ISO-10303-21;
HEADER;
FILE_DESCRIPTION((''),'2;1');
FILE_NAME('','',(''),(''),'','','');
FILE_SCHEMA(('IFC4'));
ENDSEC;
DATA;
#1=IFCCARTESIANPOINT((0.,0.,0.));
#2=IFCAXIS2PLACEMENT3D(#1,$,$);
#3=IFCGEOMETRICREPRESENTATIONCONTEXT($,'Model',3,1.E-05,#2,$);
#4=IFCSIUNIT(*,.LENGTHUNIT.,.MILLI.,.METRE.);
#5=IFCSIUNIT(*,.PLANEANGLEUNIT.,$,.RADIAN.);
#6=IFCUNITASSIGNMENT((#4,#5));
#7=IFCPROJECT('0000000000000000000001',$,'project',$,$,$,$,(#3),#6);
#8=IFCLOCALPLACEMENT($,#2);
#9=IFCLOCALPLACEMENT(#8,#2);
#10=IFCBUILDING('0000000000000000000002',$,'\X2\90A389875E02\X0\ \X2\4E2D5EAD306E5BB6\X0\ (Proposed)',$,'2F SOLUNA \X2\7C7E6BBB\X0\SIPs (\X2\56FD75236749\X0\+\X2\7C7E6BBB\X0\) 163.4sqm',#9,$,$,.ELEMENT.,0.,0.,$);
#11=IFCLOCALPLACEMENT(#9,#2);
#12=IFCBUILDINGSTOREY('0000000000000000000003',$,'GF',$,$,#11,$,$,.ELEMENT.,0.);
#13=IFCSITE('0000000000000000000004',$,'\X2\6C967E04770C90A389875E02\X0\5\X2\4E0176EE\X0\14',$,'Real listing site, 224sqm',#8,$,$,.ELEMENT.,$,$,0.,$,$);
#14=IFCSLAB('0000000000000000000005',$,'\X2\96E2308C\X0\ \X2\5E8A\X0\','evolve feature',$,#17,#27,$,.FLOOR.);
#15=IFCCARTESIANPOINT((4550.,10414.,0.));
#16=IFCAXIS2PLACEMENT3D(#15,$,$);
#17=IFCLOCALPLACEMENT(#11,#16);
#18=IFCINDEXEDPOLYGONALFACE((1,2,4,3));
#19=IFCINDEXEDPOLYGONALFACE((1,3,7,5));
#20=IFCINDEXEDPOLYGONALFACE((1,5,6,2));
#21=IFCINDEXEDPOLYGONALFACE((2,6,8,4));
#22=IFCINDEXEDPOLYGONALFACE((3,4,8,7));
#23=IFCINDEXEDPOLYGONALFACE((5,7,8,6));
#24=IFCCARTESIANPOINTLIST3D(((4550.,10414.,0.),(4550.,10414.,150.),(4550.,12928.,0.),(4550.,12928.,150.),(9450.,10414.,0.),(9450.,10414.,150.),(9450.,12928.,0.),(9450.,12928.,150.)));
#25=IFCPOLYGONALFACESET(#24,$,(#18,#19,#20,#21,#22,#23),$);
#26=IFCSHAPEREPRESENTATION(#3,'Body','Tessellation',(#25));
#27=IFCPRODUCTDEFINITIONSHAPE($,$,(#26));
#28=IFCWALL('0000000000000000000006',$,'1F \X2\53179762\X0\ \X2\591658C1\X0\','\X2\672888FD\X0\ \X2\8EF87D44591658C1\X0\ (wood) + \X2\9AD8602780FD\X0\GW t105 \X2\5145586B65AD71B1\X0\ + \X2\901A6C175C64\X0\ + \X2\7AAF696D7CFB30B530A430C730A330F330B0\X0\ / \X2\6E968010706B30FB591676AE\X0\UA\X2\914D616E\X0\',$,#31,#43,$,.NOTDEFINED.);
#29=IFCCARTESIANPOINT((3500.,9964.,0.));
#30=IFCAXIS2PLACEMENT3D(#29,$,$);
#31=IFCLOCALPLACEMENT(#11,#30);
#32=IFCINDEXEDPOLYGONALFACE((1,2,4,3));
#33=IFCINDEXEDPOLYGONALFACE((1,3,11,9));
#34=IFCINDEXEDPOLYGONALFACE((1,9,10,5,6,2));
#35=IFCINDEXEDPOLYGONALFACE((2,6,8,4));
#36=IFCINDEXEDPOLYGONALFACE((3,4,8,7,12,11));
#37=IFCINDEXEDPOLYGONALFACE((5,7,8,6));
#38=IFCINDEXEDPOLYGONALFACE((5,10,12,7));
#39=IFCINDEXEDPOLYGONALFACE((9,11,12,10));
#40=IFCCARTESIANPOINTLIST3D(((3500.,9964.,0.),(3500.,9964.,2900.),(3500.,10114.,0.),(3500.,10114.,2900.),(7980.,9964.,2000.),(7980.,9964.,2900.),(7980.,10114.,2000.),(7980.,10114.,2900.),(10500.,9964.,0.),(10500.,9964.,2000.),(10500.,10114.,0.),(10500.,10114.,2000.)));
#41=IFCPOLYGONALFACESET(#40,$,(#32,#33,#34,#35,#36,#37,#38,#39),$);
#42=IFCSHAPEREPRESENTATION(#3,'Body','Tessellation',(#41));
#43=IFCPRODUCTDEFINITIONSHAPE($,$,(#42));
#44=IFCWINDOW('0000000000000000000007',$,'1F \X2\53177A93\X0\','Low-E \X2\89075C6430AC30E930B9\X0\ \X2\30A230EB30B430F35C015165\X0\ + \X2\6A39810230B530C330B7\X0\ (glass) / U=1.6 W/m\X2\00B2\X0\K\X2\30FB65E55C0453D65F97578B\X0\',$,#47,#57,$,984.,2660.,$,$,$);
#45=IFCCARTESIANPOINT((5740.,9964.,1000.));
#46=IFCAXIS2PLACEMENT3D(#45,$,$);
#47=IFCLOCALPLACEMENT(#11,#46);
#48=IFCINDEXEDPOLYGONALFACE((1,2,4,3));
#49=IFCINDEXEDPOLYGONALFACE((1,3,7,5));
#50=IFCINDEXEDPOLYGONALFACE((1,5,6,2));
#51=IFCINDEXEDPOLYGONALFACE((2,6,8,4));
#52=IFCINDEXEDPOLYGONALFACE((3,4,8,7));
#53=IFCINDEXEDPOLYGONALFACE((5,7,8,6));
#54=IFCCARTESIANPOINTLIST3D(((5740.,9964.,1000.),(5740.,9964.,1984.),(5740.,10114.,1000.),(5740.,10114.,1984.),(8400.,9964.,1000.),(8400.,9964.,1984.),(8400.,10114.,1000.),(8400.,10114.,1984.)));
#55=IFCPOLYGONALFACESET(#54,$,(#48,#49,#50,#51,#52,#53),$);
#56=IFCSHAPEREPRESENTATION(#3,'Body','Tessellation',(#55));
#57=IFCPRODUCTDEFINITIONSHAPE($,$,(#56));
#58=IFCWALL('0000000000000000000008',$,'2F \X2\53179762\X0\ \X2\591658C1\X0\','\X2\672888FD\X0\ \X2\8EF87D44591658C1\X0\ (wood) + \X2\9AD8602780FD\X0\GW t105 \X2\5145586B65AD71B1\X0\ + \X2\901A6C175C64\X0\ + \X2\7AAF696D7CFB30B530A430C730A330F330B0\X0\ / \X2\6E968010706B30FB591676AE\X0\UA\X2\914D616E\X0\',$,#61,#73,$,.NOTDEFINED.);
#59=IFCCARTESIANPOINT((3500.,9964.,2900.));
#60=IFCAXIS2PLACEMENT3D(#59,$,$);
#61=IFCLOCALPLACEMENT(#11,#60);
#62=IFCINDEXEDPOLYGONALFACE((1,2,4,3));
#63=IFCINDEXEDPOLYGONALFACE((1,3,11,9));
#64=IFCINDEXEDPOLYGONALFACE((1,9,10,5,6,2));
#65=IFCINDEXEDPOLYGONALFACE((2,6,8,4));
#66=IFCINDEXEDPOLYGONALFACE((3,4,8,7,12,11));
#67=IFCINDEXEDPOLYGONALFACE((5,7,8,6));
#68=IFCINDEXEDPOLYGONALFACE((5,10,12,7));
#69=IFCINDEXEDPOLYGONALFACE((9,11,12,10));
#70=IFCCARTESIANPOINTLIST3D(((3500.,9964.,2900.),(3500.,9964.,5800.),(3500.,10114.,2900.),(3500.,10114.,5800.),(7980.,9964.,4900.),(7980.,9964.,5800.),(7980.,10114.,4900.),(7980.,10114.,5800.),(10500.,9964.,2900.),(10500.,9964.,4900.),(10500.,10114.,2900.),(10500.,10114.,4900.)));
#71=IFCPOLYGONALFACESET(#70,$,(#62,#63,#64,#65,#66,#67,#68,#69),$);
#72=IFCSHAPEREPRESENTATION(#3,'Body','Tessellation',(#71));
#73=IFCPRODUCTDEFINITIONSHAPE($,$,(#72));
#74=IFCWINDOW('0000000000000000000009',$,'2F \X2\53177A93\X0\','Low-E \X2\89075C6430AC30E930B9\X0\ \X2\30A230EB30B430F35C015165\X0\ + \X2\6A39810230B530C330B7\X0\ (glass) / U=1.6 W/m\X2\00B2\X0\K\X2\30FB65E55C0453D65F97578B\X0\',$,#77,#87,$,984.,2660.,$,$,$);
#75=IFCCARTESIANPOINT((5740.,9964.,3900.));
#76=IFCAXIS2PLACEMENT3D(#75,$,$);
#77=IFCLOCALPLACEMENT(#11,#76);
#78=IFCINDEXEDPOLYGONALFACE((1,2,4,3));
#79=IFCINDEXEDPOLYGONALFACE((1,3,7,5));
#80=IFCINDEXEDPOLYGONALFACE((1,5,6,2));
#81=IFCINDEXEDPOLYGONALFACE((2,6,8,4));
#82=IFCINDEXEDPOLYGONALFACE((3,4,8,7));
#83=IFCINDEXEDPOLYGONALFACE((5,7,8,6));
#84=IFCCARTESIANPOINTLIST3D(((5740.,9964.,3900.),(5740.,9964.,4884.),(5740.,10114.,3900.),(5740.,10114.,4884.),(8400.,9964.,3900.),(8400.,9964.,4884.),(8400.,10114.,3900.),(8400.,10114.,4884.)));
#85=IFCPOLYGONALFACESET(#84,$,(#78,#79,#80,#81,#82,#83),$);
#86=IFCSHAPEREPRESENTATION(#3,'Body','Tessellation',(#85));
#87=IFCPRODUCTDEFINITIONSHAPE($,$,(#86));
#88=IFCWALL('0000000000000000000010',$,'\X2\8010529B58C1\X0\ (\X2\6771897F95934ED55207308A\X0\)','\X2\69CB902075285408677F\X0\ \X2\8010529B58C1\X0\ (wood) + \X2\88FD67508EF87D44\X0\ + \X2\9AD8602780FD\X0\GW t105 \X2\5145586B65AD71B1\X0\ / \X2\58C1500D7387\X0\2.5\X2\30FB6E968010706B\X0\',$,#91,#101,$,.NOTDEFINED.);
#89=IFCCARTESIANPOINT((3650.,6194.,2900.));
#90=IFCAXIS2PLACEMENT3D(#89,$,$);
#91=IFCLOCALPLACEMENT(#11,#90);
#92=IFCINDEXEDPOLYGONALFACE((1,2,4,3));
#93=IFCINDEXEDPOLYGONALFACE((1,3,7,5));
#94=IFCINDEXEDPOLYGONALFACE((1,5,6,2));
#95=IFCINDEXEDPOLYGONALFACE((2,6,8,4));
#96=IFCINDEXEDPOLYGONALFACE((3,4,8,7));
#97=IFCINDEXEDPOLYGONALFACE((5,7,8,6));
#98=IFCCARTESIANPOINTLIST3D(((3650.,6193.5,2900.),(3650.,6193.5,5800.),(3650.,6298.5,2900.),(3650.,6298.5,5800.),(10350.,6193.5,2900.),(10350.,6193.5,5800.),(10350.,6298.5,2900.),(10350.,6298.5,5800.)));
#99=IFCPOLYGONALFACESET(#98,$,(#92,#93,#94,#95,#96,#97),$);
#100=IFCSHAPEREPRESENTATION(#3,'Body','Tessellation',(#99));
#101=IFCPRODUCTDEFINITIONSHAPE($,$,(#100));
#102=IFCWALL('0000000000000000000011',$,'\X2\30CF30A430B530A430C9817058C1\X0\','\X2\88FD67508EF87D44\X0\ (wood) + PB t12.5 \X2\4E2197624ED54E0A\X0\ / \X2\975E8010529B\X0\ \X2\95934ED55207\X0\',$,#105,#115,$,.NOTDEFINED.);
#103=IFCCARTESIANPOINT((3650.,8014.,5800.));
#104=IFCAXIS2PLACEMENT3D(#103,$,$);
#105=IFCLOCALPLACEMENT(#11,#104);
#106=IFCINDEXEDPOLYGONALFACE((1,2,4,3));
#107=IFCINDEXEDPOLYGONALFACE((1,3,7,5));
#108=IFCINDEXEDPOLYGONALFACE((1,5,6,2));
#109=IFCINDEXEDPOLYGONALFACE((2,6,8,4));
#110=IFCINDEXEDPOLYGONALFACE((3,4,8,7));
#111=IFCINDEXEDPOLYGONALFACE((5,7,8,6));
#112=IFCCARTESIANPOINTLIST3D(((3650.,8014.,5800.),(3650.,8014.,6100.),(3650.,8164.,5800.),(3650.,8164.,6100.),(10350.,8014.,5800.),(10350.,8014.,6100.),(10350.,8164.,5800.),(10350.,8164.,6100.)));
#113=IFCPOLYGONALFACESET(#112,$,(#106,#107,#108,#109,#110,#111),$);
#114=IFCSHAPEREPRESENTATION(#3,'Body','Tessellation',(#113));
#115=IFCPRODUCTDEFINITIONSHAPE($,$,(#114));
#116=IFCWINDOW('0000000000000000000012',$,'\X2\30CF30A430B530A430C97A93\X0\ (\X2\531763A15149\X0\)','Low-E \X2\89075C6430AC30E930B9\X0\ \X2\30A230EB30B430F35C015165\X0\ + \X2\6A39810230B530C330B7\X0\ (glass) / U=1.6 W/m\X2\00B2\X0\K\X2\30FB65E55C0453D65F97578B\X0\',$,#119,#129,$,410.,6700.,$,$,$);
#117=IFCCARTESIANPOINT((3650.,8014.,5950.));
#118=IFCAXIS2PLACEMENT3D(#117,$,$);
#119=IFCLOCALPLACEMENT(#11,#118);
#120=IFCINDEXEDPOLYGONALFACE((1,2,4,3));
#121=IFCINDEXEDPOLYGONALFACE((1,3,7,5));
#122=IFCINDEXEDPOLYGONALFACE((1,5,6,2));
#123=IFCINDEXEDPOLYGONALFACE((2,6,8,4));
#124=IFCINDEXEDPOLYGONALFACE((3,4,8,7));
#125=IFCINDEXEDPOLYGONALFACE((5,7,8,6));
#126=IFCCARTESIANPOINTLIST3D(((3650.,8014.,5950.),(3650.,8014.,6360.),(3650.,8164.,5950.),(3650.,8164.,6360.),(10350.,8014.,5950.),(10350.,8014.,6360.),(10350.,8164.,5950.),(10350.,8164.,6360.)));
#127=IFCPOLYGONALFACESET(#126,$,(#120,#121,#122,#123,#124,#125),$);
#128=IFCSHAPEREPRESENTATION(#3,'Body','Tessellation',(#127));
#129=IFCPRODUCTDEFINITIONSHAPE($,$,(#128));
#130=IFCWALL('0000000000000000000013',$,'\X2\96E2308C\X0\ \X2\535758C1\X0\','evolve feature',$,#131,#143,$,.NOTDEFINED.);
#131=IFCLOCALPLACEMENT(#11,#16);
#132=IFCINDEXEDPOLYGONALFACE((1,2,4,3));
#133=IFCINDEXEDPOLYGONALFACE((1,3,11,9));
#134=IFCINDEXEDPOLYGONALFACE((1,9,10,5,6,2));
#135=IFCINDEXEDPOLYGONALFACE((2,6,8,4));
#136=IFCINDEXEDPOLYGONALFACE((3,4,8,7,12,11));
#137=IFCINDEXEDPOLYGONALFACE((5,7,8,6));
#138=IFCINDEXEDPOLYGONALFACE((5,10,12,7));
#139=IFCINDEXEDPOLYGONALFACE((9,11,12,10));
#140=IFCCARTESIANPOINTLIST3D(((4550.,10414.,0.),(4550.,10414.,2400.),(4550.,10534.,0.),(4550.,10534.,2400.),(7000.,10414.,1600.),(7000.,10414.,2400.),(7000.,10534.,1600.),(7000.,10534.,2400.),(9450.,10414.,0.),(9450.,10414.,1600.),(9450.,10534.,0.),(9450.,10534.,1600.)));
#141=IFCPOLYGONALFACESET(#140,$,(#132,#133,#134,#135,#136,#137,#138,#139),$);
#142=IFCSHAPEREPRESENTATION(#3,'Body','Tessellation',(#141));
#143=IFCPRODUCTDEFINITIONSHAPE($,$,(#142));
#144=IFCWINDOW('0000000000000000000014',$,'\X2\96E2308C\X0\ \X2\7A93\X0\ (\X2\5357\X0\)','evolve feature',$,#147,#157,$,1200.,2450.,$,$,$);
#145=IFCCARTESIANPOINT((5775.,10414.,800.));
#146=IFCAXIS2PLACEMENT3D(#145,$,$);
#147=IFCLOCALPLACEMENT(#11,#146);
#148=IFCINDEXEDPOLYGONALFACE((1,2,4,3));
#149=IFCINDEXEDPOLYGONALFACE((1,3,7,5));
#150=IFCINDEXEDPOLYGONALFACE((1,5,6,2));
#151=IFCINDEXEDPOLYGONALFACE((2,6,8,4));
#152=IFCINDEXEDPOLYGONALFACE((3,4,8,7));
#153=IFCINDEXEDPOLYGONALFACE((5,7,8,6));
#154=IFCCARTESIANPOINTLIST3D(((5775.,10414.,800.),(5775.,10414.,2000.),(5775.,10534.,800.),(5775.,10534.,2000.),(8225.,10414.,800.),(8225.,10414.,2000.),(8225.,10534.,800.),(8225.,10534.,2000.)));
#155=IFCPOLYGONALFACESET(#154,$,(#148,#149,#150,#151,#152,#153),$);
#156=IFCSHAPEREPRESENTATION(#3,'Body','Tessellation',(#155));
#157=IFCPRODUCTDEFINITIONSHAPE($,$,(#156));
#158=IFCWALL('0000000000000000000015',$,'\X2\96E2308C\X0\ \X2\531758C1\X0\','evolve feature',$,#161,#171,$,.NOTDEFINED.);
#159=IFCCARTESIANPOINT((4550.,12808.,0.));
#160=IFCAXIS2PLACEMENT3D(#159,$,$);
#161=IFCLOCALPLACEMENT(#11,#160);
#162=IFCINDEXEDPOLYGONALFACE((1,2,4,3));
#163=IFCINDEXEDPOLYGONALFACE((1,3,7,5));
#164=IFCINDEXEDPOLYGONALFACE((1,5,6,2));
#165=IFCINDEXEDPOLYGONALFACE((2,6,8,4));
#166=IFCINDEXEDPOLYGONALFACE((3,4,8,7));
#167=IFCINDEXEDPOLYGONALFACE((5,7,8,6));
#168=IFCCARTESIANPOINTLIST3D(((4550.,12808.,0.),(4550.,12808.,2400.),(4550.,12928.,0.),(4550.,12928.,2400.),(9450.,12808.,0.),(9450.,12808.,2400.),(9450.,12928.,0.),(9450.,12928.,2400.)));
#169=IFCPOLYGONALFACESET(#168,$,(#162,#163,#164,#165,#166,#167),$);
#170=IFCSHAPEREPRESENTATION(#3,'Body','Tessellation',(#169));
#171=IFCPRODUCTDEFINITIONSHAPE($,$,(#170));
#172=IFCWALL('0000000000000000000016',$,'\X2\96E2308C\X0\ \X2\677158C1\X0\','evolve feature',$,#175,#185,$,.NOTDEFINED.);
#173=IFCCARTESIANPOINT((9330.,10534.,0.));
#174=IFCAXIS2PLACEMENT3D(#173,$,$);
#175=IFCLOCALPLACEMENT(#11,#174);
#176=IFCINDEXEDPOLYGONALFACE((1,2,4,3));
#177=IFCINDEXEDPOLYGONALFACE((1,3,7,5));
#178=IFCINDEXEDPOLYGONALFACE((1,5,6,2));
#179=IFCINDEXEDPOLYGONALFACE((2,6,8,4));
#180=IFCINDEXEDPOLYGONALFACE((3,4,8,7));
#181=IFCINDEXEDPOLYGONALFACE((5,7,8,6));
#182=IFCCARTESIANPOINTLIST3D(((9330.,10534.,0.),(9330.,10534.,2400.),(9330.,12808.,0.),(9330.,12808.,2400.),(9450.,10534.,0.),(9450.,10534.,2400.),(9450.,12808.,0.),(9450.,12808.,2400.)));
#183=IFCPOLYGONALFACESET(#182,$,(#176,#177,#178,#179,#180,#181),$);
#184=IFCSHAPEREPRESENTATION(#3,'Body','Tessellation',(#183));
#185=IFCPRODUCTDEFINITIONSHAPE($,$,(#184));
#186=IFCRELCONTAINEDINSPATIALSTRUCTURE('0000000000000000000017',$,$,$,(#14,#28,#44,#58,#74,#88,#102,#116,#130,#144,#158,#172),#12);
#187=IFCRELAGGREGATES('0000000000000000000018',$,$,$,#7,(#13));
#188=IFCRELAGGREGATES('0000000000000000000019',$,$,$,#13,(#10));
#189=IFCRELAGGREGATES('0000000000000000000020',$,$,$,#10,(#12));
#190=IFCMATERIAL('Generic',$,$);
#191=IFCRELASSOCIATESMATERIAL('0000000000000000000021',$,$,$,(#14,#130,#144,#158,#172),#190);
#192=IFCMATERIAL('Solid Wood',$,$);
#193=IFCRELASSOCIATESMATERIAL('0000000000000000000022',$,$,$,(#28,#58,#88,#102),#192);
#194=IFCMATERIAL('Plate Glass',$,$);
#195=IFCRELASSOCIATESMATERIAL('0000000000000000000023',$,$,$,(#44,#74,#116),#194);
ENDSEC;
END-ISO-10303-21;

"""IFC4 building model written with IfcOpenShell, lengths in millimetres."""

from ifc_helpers import new_model, si_unit, frame, frame_2d, origin, place, context, project, spatial, rectangle, extrude, material, element, fill, save


model = new_model("IFC4")

# Units and contexts
model_context = context("Model", 3, precision=1e-05, world=origin())
ifc_project = project(units=[si_unit("LENGTHUNIT", "METRE", prefix="MILLI"), si_unit("PLANEANGLEUNIT", "RADIAN")], contexts=[model_context])

# Site, building, storey
site_placement = place(None, origin())
site = spatial("IfcSite", under=ifc_project, at=site_placement, Name="沖縄県那覇市5丁目14", ObjectType="Real listing site, 224sqm", CompositionType="ELEMENT", RefElevation=0.0)
building_placement = place(site_placement, origin())
building = spatial("IfcBuilding", under=site, at=building_placement, Name="那覇市 中庭の家 (Proposed)", ObjectType="2F SOLUNA 籾殻SIPs (国産杉+籾殻) 163.4sqm", CompositionType="ELEMENT", ElevationOfRefHeight=0.0, ElevationOfTerrain=0.0)
storey_placement = place(building_placement, origin())
storey = spatial("IfcBuildingStorey", under=building, at=storey_placement, Name="GF", CompositionType="ELEMENT", Elevation=0.0)

# Slab
ifc_material_1 = material(Name="Generic")
slab_placement = place(storey_placement, frame((4550.0, 10414.0, 0.0)))
element("IfcSlab", 1, at=slab_placement, inside=storey, material=ifc_material_1, Name="離れ 床", Description="evolve feature", PredefinedType="FLOOR", context=model_context, shape_type="SweptSolid", body=[
    extrude(rectangle(XDim=4900.0, YDim=2514.0, at=frame_2d((2450.0, 1257.0))), frame((4550.0, 10414.0, 0.0)), (0.0, 0.0, 1.0), 150.0),
])

# Wall, opening, window
ifc_material_2 = material(Name="Solid Wood")
wall_1_placement = place(storey_placement, frame((3500.0, 9964.0, 0.0)))
wall_1 = element("IfcWall", 2, at=wall_1_placement, inside=storey, material=ifc_material_2, Name="1F 北面 外壁", Description="木製 軸組外壁 (wood) + 高性能GW t105 充填断熱 + 通気層 + 窯業系サイディング / 準耐火・外皮UA配慮", PredefinedType="NOTDEFINED", context=model_context, shape_type="SweptSolid", body=[
    extrude(rectangle(XDim=7000.0, YDim=150.0, at=frame_2d((3500.0, 75.0))), frame((3500.0, 9964.0, 0.0)), (0.0, 0.0, 1.0), 2900.0),
])
opening_1_placement = place(storey_placement, frame((5740.0, 9964.0, 1000.0)))
opening_1 = element("IfcOpeningElement", 3, at=opening_1_placement, cuts=wall_1, PredefinedType="NOTDEFINED", context=model_context, shape_type="SweptSolid", body=[
    extrude(rectangle(XDim=2660.0, YDim=150.0, at=frame_2d((1330.0, 75.0))), frame((5740.0, 9964.0, 1000.0)), (0.0, 0.0, 1.0), 984.0),
])
ifc_material_3 = material(Name="Plate Glass")
window_1_placement = place(storey_placement, frame((5740.0, 9964.0, 1000.0)))
window_1 = element("IfcWindow", 4, at=window_1_placement, inside=storey, material=ifc_material_3, Name="1F 北窓", Description="Low-E 複層ガラス アルゴン封入 + 樹脂サッシ (glass) / U=1.6 W/m²K・日射取得型", OverallHeight=984.0, OverallWidth=2660.0, context=model_context, shape_type="SweptSolid", body=[
    extrude(rectangle(XDim=2660.0, YDim=150.0, at=frame_2d((1330.0, 75.0))), frame((5740.0, 9964.0, 1000.0)), (0.0, 0.0, 1.0), 984.0),
])
fill(opening_1, window_1)

# Wall, opening, window
wall_2_placement = place(storey_placement, frame((3500.0, 9964.0, 2900.0)))
wall_2 = element("IfcWall", 5, at=wall_2_placement, inside=storey, material=ifc_material_2, Name="2F 北面 外壁", Description="木製 軸組外壁 (wood) + 高性能GW t105 充填断熱 + 通気層 + 窯業系サイディング / 準耐火・外皮UA配慮", PredefinedType="NOTDEFINED", context=model_context, shape_type="SweptSolid", body=[
    extrude(rectangle(XDim=7000.0, YDim=150.0, at=frame_2d((3500.0, 75.0))), frame((3500.0, 9964.0, 2900.0)), (0.0, 0.0, 1.0), 2900.0),
])
opening_2_placement = place(storey_placement, frame((5740.0, 9964.0, 3900.0)))
opening_2 = element("IfcOpeningElement", 6, at=opening_2_placement, cuts=wall_2, PredefinedType="NOTDEFINED", context=model_context, shape_type="SweptSolid", body=[
    extrude(rectangle(XDim=2660.0, YDim=150.0, at=frame_2d((1330.0, 75.0))), frame((5740.0, 9964.0, 3900.0)), (0.0, 0.0, 1.0), 984.0),
])
window_2_placement = place(storey_placement, frame((5740.0, 9964.0, 3900.0)))
window_2 = element("IfcWindow", 7, at=window_2_placement, inside=storey, material=ifc_material_3, Name="2F 北窓", Description="Low-E 複層ガラス アルゴン封入 + 樹脂サッシ (glass) / U=1.6 W/m²K・日射取得型", OverallHeight=984.0, OverallWidth=2660.0, context=model_context, shape_type="SweptSolid", body=[
    extrude(rectangle(XDim=2660.0, YDim=150.0, at=frame_2d((1330.0, 75.0))), frame((5740.0, 9964.0, 3900.0)), (0.0, 0.0, 1.0), 984.0),
])
fill(opening_2, window_2)

# Wall
wall_3_placement = place(storey_placement, frame((3650.0, 6194.0, 2900.0)))
element("IfcWall", 8, at=wall_3_placement, inside=storey, material=ifc_material_2, Name="耐力壁 (東西間仕切り)", Description="構造用合板 耐力壁 (wood) + 製材軸組 + 高性能GW t105 充填断熱 / 壁倍率2.5・準耐火", PredefinedType="NOTDEFINED", context=model_context, shape_type="SweptSolid", body=[
    extrude(rectangle(XDim=6700.0, YDim=105.0, at=frame_2d((3350.0, 52.0))), frame((3650.0, 6194.0, 2900.0)), (0.0, 0.0, 1.0), 2900.0),
])

# Walls, openings, windows
wall_4_placement = place(storey_placement, frame((3650.0, 8014.0, 5800.0)))
wall_4 = element("IfcWall", 9, at=wall_4_placement, inside=storey, material=ifc_material_2, Name="ハイサイド腰壁", Description="製材軸組 (wood) + PB t12.5 両面仕上 / 非耐力 間仕切", PredefinedType="NOTDEFINED", context=model_context, shape_type="SweptSolid", body=[
    extrude(rectangle(XDim=6700.0, YDim=150.0, at=frame_2d((3350.0, 75.0))), frame((3650.0, 8014.0, 5800.0)), (0.0, 0.0, 1.0), 700.0),
])
opening_3_placement = place(storey_placement, frame((3650.0, 8014.0, 5950.0)))
opening_3 = element("IfcOpeningElement", 10, at=opening_3_placement, cuts=wall_4, PredefinedType="NOTDEFINED", context=model_context, shape_type="SweptSolid", body=[
    extrude(rectangle(XDim=6700.0, YDim=150.0, at=frame_2d((3350.0, 75.0))), frame((3650.0, 8014.0, 5950.0)), (0.0, 0.0, 1.0), 410.0),
])
window_3_placement = place(storey_placement, frame((3650.0, 8014.0, 5950.0)))
window_3 = element("IfcWindow", 11, at=window_3_placement, inside=storey, material=ifc_material_3, Name="ハイサイド窓 (北採光)", Description="Low-E 複層ガラス アルゴン封入 + 樹脂サッシ (glass) / U=1.6 W/m²K・日射取得型", OverallHeight=410.0, OverallWidth=6700.0, context=model_context, shape_type="SweptSolid", body=[
    extrude(rectangle(XDim=6700.0, YDim=150.0, at=frame_2d((3350.0, 75.0))), frame((3650.0, 8014.0, 5950.0)), (0.0, 0.0, 1.0), 410.0),
])
fill(opening_3, window_3)
wall_5_placement = place(storey_placement, frame((4550.0, 10414.0, 0.0)))
wall_5 = element("IfcWall", 12, at=wall_5_placement, inside=storey, material=ifc_material_1, Name="離れ 南壁", Description="evolve feature", PredefinedType="NOTDEFINED", context=model_context, shape_type="SweptSolid", body=[
    extrude(rectangle(XDim=4900.0, YDim=120.0, at=frame_2d((2450.0, 60.0))), frame((4550.0, 10414.0, 0.0)), (0.0, 0.0, 1.0), 2400.0),
])
opening_4_placement = place(storey_placement, frame((5775.0, 10414.0, 800.0)))
opening_4 = element("IfcOpeningElement", 13, at=opening_4_placement, cuts=wall_5, PredefinedType="NOTDEFINED", context=model_context, shape_type="SweptSolid", body=[
    extrude(rectangle(XDim=2450.0, YDim=120.0, at=frame_2d((1225.0, 60.0))), frame((5775.0, 10414.0, 800.0)), (0.0, 0.0, 1.0), 1200.0),
])
window_4_placement = place(storey_placement, frame((5775.0, 10414.0, 800.0)))
window_4 = element("IfcWindow", 14, at=window_4_placement, inside=storey, material=ifc_material_1, Name="離れ 窓 (南)", Description="evolve feature", OverallHeight=1200.0, OverallWidth=2450.0, context=model_context, shape_type="SweptSolid", body=[
    extrude(rectangle(XDim=2450.0, YDim=120.0, at=frame_2d((1225.0, 60.0))), frame((5775.0, 10414.0, 800.0)), (0.0, 0.0, 1.0), 1200.0),
])
fill(opening_4, window_4)

# Walls
wall_6_placement = place(storey_placement, frame((4550.0, 12808.0, 0.0)))
element("IfcWall", 15, at=wall_6_placement, inside=storey, material=ifc_material_1, Name="離れ 北壁", Description="evolve feature", PredefinedType="NOTDEFINED", context=model_context, shape_type="SweptSolid", body=[
    extrude(rectangle(XDim=4900.0, YDim=120.0, at=frame_2d((2450.0, 60.0))), frame((4550.0, 12808.0, 0.0)), (0.0, 0.0, 1.0), 2400.0),
])
wall_7_placement = place(storey_placement, frame((9330.0, 10534.0, 0.0)))
element("IfcWall", 16, at=wall_7_placement, inside=storey, material=ifc_material_1, Name="離れ 東壁", Description="evolve feature", PredefinedType="NOTDEFINED", context=model_context, shape_type="SweptSolid", body=[
    extrude(rectangle(XDim=120.0, YDim=2274.0, at=frame_2d((60.0, 1137.0))), frame((9330.0, 10534.0, 0.0)), (0.0, 0.0, 1.0), 2400.0),
])

save(model, "model.ifc")
